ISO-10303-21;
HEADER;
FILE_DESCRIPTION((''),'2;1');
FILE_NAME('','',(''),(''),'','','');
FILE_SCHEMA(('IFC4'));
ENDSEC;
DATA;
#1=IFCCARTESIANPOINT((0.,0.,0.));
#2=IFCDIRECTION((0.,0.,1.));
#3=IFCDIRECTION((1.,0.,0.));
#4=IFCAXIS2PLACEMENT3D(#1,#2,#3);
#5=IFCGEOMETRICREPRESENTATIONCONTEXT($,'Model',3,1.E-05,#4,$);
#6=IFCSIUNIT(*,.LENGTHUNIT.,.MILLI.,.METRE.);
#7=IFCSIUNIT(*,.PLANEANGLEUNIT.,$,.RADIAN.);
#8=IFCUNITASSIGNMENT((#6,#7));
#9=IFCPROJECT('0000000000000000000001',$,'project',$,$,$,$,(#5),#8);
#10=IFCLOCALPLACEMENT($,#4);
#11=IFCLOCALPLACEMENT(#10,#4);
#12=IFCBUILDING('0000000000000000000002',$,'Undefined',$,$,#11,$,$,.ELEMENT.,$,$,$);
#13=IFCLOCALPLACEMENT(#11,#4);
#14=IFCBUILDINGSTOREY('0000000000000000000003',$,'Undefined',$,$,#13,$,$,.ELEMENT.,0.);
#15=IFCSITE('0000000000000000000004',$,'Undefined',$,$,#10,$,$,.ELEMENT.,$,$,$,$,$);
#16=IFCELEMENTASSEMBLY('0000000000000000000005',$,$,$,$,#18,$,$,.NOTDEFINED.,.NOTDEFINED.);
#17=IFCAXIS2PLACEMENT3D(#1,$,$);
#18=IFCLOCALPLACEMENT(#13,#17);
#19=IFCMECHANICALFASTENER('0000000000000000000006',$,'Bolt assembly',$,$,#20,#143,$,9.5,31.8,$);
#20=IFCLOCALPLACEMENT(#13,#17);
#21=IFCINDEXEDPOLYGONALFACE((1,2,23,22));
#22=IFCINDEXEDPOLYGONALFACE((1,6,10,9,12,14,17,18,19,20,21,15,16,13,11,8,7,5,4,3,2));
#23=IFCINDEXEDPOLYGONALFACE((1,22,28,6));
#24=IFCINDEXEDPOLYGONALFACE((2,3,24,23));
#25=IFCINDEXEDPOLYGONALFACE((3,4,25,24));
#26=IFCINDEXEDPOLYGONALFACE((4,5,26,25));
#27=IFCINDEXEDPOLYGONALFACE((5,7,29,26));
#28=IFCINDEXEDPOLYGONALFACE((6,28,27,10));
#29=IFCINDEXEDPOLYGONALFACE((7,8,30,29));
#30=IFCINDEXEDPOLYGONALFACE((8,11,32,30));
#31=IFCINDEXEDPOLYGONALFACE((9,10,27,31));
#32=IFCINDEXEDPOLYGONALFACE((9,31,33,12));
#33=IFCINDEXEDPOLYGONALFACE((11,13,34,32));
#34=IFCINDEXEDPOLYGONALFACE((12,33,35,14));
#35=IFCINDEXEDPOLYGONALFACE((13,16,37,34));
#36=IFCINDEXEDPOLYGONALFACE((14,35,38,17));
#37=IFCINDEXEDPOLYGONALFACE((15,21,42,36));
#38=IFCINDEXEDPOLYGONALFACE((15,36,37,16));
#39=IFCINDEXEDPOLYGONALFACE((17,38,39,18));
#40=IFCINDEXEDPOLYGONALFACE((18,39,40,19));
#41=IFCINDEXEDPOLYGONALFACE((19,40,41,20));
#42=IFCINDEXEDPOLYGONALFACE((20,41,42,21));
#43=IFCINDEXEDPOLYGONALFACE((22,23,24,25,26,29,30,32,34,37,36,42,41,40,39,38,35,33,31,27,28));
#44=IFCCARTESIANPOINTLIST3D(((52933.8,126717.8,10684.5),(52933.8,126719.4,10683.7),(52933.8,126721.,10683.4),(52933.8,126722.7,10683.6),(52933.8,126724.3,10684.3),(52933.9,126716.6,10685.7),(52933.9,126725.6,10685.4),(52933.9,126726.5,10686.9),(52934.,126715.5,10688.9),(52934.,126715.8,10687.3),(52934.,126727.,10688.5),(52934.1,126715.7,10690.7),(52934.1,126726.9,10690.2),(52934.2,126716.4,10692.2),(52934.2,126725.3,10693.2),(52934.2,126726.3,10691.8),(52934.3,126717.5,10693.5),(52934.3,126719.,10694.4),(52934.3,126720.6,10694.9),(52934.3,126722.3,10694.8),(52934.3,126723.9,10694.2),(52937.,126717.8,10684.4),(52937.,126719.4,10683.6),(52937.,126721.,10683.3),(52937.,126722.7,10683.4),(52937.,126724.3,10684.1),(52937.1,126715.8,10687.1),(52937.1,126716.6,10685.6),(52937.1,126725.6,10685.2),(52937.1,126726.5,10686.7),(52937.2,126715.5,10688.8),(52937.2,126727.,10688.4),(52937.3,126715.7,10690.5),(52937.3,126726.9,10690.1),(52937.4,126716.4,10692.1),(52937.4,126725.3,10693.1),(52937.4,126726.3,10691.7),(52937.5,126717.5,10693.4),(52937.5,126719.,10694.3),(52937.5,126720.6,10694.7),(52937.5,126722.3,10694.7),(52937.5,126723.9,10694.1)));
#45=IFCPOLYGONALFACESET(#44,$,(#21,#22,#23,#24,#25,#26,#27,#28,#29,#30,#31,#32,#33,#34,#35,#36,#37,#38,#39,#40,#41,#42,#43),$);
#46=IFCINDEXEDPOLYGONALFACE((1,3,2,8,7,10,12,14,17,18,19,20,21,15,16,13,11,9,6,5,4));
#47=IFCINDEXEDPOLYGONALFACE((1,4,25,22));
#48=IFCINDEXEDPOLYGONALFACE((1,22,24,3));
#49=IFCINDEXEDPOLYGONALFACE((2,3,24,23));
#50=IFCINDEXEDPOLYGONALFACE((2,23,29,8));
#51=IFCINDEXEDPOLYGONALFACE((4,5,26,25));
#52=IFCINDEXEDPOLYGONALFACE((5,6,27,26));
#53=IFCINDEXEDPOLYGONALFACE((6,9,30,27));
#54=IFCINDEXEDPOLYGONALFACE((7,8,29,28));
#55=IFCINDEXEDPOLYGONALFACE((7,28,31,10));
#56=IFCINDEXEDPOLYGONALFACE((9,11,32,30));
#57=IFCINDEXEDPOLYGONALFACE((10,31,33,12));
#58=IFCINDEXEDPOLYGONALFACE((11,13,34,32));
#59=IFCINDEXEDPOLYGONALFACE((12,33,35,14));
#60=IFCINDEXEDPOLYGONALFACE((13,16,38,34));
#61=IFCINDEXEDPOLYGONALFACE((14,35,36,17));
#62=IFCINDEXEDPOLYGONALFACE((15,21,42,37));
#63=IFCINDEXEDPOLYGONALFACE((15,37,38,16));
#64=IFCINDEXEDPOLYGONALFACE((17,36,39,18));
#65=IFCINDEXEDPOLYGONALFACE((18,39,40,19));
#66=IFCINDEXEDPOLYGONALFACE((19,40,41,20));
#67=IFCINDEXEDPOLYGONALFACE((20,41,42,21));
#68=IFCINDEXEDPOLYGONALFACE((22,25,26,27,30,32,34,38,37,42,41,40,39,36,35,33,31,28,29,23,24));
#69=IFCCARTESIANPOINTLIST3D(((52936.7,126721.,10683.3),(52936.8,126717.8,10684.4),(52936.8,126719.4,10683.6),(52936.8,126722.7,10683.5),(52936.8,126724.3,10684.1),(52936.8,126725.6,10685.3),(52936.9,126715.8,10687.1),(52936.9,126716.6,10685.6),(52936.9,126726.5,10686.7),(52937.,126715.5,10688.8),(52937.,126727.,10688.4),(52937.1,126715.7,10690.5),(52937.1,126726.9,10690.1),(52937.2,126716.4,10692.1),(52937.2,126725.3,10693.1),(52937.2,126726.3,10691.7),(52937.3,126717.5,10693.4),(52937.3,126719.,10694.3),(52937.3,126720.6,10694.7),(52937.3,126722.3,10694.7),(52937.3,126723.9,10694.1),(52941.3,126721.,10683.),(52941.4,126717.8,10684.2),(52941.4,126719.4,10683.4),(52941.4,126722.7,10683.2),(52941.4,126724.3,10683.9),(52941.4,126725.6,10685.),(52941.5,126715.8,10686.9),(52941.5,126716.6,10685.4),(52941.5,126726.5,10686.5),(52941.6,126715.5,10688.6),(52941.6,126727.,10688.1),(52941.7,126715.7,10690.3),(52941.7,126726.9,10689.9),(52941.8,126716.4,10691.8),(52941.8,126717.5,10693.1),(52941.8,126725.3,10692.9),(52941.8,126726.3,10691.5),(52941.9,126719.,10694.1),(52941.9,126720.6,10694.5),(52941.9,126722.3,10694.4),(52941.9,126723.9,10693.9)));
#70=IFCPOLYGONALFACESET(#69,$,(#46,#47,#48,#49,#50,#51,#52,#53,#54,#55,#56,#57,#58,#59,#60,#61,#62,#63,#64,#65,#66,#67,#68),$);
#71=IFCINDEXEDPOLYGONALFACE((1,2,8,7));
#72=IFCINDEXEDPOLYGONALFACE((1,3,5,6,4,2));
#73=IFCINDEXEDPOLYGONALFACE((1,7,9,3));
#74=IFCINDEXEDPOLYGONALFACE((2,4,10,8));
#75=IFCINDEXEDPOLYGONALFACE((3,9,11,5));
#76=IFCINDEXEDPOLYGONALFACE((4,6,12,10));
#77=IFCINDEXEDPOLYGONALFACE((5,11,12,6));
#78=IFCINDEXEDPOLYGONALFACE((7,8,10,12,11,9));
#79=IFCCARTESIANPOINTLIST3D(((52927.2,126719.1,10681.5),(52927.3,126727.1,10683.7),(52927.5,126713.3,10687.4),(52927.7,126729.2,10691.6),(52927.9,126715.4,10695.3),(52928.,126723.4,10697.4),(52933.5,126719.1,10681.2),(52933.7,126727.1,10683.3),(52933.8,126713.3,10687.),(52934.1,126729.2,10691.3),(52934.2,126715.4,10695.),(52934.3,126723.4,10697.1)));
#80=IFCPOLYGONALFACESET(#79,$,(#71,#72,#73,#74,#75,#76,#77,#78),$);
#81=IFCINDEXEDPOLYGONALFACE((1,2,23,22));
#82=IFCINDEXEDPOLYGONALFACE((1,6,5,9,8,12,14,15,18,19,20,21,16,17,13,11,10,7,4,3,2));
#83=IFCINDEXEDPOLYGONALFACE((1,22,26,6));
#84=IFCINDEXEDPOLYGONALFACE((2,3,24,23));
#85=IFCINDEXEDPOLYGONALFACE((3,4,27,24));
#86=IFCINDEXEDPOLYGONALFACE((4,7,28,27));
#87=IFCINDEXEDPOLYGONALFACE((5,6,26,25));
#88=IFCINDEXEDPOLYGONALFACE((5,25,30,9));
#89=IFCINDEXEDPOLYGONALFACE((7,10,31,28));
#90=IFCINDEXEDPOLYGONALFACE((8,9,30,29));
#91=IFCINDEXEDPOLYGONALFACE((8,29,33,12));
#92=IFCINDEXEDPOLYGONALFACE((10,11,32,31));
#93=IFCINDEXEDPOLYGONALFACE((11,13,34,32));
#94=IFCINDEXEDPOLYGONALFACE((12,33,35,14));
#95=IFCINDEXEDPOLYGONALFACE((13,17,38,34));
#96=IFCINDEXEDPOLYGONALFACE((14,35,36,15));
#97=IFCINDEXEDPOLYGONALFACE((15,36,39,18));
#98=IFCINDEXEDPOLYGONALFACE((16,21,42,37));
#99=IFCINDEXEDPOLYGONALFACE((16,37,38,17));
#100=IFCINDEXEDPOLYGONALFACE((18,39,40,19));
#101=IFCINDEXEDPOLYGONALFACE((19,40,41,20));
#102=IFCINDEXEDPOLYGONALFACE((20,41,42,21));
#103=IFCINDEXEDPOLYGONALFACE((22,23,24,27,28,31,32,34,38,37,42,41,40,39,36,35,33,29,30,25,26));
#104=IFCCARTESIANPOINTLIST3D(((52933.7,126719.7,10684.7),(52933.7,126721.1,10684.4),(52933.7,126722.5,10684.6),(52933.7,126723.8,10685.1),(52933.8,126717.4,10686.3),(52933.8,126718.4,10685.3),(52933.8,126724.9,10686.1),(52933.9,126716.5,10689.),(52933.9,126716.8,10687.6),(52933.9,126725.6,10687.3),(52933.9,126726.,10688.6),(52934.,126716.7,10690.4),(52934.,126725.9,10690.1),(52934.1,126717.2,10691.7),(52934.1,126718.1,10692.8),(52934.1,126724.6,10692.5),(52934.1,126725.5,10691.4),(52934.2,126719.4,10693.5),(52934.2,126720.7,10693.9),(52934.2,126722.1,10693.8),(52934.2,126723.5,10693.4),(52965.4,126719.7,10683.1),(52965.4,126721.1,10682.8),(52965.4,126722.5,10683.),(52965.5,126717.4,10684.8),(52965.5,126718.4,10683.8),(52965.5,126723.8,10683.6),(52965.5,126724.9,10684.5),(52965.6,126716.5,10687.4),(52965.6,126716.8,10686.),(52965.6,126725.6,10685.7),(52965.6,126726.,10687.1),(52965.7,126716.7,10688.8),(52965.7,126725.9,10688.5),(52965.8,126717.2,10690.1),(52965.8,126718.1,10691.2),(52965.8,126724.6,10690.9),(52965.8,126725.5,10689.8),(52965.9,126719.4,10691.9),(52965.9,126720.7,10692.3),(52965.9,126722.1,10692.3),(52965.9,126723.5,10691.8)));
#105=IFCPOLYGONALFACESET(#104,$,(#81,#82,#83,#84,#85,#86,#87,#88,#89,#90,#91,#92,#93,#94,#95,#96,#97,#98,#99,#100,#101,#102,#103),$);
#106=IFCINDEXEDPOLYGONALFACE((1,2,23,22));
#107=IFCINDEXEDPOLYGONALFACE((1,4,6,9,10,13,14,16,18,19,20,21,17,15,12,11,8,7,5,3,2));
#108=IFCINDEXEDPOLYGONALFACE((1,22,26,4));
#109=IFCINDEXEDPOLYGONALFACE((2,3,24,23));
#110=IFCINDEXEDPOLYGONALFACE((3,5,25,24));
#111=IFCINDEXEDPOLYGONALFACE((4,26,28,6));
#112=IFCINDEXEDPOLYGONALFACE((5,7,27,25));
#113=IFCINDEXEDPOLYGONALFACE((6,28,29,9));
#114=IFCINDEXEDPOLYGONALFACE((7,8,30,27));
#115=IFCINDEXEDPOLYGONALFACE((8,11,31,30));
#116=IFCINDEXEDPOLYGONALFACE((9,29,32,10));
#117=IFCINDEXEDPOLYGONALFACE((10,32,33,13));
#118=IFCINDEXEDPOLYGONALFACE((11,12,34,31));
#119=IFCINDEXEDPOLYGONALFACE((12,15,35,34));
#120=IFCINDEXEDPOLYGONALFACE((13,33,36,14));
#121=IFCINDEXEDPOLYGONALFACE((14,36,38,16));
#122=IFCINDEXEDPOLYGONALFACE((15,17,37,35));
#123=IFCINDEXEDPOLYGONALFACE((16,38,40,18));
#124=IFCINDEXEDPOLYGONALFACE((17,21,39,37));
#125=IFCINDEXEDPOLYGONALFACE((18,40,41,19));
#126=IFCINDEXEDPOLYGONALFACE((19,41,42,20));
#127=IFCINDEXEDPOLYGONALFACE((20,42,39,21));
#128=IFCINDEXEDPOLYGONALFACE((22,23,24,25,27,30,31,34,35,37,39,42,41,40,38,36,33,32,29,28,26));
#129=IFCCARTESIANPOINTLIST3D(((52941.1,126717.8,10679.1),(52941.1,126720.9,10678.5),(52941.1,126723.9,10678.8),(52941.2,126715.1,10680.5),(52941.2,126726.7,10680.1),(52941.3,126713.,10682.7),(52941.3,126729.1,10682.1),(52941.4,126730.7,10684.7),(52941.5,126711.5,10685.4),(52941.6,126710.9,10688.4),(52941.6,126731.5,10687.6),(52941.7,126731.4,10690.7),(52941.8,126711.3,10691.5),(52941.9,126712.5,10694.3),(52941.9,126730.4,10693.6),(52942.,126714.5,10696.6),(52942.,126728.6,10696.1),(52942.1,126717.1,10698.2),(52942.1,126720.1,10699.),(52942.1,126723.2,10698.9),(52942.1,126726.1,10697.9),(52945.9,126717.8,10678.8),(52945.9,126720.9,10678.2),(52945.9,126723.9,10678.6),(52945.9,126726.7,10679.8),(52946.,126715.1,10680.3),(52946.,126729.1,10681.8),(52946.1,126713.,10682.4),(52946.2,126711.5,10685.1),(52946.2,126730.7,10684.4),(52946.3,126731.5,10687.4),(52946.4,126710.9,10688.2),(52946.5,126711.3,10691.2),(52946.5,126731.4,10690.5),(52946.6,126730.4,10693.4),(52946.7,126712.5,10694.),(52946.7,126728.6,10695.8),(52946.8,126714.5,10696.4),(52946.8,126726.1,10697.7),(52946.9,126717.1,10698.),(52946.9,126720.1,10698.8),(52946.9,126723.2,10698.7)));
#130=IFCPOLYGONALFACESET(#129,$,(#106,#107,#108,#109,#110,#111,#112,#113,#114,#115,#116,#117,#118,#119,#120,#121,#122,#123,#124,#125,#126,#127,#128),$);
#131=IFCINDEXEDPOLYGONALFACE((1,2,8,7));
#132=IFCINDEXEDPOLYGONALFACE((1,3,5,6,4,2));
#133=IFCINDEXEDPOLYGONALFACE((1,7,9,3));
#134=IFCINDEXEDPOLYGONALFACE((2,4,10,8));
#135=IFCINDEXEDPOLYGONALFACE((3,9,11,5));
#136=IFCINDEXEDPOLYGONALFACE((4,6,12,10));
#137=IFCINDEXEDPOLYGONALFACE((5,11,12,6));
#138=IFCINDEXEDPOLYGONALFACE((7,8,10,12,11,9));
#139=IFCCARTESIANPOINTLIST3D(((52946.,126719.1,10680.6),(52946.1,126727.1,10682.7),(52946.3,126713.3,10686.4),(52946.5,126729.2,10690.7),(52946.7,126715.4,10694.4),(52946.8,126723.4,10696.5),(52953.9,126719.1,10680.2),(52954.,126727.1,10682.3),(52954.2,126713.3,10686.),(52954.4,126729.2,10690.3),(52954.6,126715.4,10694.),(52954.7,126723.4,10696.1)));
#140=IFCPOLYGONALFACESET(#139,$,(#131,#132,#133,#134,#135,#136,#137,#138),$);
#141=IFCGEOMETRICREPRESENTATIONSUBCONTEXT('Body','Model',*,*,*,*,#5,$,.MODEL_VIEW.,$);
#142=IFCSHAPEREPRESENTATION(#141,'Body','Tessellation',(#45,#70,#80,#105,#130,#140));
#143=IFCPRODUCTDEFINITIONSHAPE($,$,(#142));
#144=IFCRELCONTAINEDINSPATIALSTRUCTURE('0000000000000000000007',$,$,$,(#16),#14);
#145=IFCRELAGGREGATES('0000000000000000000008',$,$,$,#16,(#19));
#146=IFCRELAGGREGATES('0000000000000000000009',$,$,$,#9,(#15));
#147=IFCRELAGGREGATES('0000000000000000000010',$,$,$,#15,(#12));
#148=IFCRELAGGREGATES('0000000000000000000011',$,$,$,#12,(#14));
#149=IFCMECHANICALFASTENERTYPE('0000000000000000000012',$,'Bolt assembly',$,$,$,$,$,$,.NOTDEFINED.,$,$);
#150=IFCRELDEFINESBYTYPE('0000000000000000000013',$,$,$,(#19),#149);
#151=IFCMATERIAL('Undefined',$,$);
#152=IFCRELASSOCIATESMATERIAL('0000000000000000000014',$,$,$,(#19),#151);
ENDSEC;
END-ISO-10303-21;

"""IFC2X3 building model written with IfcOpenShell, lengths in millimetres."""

from ifc_helpers import new_model, si_unit, frame, origin_with_axes, origin_2d_with_axis, place, context, subcontext, project, spatial, polyline, circle, outline, extrude, source, transform, mapped, material, type_object, element, aggregate, save


model = new_model("IFC2X3")

# Units and contexts
model_context = context("Model", 3, precision=1e-05, world=origin_with_axes())
body_context = subcontext(model_context, "Body", "Model", "MODEL_VIEW")
ifc_project = project(units=[si_unit("LENGTHUNIT", "METRE", prefix="MILLI"), si_unit("PLANEANGLEUNIT", "RADIAN")], contexts=[model_context])

# Site, building, storey
site_placement = place(None, origin_with_axes())
site = spatial("IfcSite", under=ifc_project, at=site_placement, Name="Undefined", CompositionType="ELEMENT")
building_placement = place(site_placement, origin_with_axes())
building = spatial("IfcBuilding", under=site, at=building_placement, Name="Undefined", CompositionType="ELEMENT")
storey_placement = place(building_placement, origin_with_axes())
storey = spatial("IfcBuildingStorey", under=building, at=storey_placement, Name="Undefined", CompositionType="ELEMENT", Elevation=0.0)

# Element assembly
assembly_1_placement = place(storey_placement, origin_with_axes())
assembly_1 = element("IfcElementAssembly", 1, at=assembly_1_placement, inside=storey, AssemblyPlace="NOTDEFINED", PredefinedType="NOTDEFINED")

# Shared definitions
ifc_material_1 = material(Name="Undefined")
mechanical_fastener_type = type_object("IfcMechanicalFastenerType", Name="Bolt assembly")

# Mechanical fastener
shared_shape_1 = source(origin_with_axes(), body_context, "Body", "SweptSolid", [
    extrude(circle(Radius=5.8, at=origin_2d_with_axis()), frame((0.0, -7.6, 0.0), z_axis=(0.0, 1.0, 0.0), x_axis=(1.0, 0.0, 0.0)), (0.0, 0.0, 1.0), 3.2),
    extrude(circle(Radius=5.8, at=origin_2d_with_axis()), frame((0.0, -4.6, 0.0), z_axis=(0.0, 1.0, 0.0), x_axis=(1.0, 0.0, 0.0)), (0.0, 0.0, 1.0), 4.6),
    extrude(outline(polyline([(7.1, -4.1), (7.1, 4.1), (0.0, 8.2), (-7.1, 4.1), (-7.1, -4.1), (0.0, -8.2), (7.1, -4.1)])), frame((0.0, -14.0, 0.0), z_axis=(0.0, 1.0, 0.0), x_axis=(1.0, 0.0, 0.0)), (0.0, 0.0, 1.0), 6.3),
    extrude(circle(Radius=4.8, at=origin_2d_with_axis()), frame((0.0, -7.7, 0.0), z_axis=(0.0, 1.0, 0.0), x_axis=(1.0, 0.0, 0.0)), (0.0, 0.0, 1.0), 31.8),
    extrude(circle(Radius=10.3, at=origin_2d_with_axis()), frame((0.0, 0.0, 0.0), z_axis=(0.0, 1.0, 0.0), x_axis=(1.0, 0.0, 0.0)), (0.0, 0.0, 1.0), 4.8),
    extrude(outline(polyline([(7.1, -4.1), (7.1, 4.1), (0.0, 8.2), (-7.1, 4.1), (-7.1, -4.1), (0.0, -8.2), (7.1, -4.1)])), frame((0.0, 4.8, 0.0), z_axis=(0.0, 1.0, 0.0), x_axis=(1.0, 0.0, 0.0)), (0.0, 0.0, 1.0), 7.9),
])
mechanical_fastener_1_placement = place(assembly_1_placement, frame((52941.6, 126721.3, 10688.8), z_axis=(-0.035282, 0.707107, -0.706226), x_axis=(0.035281, 0.707107, 0.706226)))
mechanical_fastener_1 = element("IfcMechanicalFastener", 2, at=mechanical_fastener_1_placement, type_object=mechanical_fastener_type, material=ifc_material_1, Name="Bolt assembly", NominalDiameter=9.5, NominalLength=31.8, context=body_context, shape_type="MappedRepresentation", body=[
    mapped(shared_shape_1, transform((0.0, 0.0, 0.0))),
])
aggregate(assembly_1, [mechanical_fastener_1])

save(model, "model.ifc")
